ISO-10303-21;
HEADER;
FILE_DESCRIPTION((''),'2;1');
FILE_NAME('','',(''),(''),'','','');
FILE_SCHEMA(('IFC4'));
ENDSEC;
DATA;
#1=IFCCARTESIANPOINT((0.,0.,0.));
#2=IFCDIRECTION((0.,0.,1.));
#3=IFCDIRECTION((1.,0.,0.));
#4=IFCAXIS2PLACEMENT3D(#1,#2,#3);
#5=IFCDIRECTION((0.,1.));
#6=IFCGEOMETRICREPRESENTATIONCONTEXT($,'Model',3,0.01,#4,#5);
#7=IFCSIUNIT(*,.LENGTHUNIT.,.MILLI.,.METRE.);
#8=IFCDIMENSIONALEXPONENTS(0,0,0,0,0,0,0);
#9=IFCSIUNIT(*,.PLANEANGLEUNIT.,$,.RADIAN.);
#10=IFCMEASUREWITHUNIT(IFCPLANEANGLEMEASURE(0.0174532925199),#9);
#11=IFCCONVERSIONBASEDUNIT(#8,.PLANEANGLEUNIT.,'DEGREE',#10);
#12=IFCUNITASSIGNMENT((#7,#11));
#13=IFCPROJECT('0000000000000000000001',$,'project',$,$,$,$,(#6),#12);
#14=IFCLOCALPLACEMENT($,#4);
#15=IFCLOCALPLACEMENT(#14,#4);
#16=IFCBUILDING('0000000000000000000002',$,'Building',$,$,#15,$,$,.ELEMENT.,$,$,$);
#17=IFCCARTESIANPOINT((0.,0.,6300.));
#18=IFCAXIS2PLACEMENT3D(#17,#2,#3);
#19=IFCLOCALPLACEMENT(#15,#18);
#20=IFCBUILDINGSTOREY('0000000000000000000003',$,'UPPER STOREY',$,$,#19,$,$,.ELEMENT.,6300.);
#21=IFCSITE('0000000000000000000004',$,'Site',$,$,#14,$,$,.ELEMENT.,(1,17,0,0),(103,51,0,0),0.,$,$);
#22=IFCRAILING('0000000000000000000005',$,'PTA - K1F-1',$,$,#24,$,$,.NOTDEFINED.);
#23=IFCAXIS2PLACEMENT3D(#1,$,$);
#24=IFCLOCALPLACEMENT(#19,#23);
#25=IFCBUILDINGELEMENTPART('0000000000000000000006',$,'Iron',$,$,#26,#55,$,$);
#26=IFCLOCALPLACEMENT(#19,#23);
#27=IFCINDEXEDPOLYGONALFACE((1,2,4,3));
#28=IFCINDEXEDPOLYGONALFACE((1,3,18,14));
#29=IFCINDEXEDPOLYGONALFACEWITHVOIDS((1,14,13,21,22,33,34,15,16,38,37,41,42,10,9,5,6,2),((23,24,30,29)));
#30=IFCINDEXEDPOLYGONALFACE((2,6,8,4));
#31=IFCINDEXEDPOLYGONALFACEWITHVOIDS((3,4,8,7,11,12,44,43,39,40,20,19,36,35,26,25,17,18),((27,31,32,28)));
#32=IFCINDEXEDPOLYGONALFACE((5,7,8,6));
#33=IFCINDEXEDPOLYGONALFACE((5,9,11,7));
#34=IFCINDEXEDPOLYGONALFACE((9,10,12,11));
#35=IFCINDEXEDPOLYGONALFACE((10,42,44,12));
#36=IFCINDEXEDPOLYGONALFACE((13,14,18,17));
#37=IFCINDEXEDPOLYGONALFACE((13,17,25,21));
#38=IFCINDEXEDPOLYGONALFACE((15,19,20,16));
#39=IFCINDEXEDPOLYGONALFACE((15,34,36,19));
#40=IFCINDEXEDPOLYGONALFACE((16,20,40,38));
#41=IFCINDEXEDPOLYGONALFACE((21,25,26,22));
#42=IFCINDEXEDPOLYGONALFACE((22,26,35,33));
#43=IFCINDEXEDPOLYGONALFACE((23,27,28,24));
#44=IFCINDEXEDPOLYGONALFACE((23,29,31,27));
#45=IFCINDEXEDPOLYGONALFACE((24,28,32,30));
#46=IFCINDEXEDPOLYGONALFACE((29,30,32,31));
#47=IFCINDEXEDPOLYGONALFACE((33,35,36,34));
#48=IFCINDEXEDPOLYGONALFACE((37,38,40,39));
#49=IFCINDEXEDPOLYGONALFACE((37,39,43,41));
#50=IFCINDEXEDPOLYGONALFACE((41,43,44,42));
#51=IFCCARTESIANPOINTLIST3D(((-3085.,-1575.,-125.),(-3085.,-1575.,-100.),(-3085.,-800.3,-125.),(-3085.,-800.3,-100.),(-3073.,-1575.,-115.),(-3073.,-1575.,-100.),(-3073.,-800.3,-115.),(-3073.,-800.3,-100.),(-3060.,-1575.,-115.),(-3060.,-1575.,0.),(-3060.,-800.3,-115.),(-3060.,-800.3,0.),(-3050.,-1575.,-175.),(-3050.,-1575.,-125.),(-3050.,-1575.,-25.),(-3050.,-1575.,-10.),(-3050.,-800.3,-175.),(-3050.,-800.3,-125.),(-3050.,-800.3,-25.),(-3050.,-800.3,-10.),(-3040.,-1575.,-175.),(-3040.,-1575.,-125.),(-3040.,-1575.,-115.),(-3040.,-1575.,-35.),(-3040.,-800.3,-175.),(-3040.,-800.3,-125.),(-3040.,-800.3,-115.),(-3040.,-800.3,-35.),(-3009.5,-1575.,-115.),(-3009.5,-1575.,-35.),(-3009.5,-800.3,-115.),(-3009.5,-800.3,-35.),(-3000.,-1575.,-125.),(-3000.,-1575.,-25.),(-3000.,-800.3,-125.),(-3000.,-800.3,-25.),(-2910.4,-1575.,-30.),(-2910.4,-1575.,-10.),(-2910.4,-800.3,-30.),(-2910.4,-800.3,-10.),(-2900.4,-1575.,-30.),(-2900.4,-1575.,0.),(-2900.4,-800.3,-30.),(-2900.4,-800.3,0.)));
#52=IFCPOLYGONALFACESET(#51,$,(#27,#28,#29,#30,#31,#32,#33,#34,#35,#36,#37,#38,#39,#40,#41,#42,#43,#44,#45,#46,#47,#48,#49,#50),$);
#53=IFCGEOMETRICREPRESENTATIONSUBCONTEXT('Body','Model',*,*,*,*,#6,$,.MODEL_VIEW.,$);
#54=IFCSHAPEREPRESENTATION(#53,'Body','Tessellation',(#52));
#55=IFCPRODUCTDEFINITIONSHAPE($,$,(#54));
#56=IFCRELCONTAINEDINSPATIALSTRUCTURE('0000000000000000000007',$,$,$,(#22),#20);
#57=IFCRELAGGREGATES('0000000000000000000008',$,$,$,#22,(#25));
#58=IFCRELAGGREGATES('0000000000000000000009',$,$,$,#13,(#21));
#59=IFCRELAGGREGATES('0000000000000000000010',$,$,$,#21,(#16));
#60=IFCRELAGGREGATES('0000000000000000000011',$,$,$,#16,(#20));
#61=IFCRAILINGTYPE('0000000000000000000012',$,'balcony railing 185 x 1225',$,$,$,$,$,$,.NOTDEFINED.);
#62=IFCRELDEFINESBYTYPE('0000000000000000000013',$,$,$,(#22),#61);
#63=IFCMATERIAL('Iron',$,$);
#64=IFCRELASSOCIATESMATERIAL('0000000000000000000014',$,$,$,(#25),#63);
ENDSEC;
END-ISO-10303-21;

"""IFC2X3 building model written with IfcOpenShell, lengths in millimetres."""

from ifc_helpers import new_model, entity, si_unit, converted_unit, direction, frame, origin_with_axes, place, context, subcontext, project, spatial, polyline, outline, extrude, material, type_object, element, aggregate, save


model = new_model("IFC2X3")

# Units and contexts
model_context = context("Model", 3, precision=0.01, world=origin_with_axes(), true_north=direction((0.0, 1.0)))
body_context = subcontext(model_context, "Body", "Model", "MODEL_VIEW")
ifc_project = project(units=[si_unit("LENGTHUNIT", "METRE", prefix="MILLI"), converted_unit("PLANEANGLEUNIT", "DEGREE", entity("IfcPlaneAngleMeasure", 0.0174532925199), si_unit("PLANEANGLEUNIT", "RADIAN"), dimensions=[0, 0, 0, 0, 0, 0, 0])], contexts=[model_context])

# Site, building, storey
site_placement = place(None, origin_with_axes())
site = spatial("IfcSite", under=ifc_project, at=site_placement, Name="Site", CompositionType="ELEMENT", RefLatitude=(1, 17, 0, 0), RefLongitude=(103, 51, 0, 0), RefElevation=0.0)
building_placement = place(site_placement, origin_with_axes())
building = spatial("IfcBuilding", under=site, at=building_placement, Name="Building", CompositionType="ELEMENT")
storey_placement = place(building_placement, frame((0.0, 0.0, 6300.0), z_axis=(0.0, 0.0, 1.0), x_axis=(1.0, 0.0, 0.0)))
storey = spatial("IfcBuildingStorey", under=building, at=storey_placement, Name="UPPER STOREY", CompositionType="ELEMENT", Elevation=6300.0)

# Shared definitions
ifc_material_1 = material(Name="Iron")

# Railing, building element part
railing_type_1 = type_object("IfcRailingType", Name="balcony railing 185 x 1225", PredefinedType="NOTDEFINED")
railing_1_placement = place(storey_placement, frame((-3000.0, -1575.0, -175.0), z_axis=(0.0, 0.0, 1.0), x_axis=(0.0, 1.0, 0.0)))
railing_1 = element("IfcRailing", 1, at=railing_1_placement, inside=storey, type_object=railing_type_1, Name="PTA - K1F-1", PredefinedType="NOTDEFINED")
building_element_part_1_placement = place(railing_1_placement, origin_with_axes())
building_element_part_1 = element("IfcBuildingElementPart", 2, at=building_element_part_1_placement, material=ifc_material_1, Name="Iron", context=body_context, shape_type="SweptSolid", body=[
    extrude(outline(polyline([(0.0, 150.0), (0.0, 50.0), (40.0, 50.0), (40.0, 0.0), (50.0, 0.0), (50.0, 50.0), (85.0, 50.0), (85.0, 75.0), (73.0, 75.0), (73.0, 60.0), (60.0, 60.0), (60.0, 175.0), (-99.6, 175.0), (-99.6, 145.0), (-89.6, 145.0), (-89.6, 165.0), (50.0, 165.0), (50.0, 150.0), (0.0, 150.0)]), holes=[polyline([(9.5, 140.0), (40.0, 140.0), (40.0, 60.0), (9.5, 60.0), (9.5, 140.0)])]), frame((0.0, 0.0, 0.0), z_axis=(1.0, 0.0, 0.0), x_axis=(0.0, 1.0, 0.0)), (0.0, 0.0, 1.0), 774.7),
])
aggregate(railing_1, [building_element_part_1])

save(model, "model.ifc")
